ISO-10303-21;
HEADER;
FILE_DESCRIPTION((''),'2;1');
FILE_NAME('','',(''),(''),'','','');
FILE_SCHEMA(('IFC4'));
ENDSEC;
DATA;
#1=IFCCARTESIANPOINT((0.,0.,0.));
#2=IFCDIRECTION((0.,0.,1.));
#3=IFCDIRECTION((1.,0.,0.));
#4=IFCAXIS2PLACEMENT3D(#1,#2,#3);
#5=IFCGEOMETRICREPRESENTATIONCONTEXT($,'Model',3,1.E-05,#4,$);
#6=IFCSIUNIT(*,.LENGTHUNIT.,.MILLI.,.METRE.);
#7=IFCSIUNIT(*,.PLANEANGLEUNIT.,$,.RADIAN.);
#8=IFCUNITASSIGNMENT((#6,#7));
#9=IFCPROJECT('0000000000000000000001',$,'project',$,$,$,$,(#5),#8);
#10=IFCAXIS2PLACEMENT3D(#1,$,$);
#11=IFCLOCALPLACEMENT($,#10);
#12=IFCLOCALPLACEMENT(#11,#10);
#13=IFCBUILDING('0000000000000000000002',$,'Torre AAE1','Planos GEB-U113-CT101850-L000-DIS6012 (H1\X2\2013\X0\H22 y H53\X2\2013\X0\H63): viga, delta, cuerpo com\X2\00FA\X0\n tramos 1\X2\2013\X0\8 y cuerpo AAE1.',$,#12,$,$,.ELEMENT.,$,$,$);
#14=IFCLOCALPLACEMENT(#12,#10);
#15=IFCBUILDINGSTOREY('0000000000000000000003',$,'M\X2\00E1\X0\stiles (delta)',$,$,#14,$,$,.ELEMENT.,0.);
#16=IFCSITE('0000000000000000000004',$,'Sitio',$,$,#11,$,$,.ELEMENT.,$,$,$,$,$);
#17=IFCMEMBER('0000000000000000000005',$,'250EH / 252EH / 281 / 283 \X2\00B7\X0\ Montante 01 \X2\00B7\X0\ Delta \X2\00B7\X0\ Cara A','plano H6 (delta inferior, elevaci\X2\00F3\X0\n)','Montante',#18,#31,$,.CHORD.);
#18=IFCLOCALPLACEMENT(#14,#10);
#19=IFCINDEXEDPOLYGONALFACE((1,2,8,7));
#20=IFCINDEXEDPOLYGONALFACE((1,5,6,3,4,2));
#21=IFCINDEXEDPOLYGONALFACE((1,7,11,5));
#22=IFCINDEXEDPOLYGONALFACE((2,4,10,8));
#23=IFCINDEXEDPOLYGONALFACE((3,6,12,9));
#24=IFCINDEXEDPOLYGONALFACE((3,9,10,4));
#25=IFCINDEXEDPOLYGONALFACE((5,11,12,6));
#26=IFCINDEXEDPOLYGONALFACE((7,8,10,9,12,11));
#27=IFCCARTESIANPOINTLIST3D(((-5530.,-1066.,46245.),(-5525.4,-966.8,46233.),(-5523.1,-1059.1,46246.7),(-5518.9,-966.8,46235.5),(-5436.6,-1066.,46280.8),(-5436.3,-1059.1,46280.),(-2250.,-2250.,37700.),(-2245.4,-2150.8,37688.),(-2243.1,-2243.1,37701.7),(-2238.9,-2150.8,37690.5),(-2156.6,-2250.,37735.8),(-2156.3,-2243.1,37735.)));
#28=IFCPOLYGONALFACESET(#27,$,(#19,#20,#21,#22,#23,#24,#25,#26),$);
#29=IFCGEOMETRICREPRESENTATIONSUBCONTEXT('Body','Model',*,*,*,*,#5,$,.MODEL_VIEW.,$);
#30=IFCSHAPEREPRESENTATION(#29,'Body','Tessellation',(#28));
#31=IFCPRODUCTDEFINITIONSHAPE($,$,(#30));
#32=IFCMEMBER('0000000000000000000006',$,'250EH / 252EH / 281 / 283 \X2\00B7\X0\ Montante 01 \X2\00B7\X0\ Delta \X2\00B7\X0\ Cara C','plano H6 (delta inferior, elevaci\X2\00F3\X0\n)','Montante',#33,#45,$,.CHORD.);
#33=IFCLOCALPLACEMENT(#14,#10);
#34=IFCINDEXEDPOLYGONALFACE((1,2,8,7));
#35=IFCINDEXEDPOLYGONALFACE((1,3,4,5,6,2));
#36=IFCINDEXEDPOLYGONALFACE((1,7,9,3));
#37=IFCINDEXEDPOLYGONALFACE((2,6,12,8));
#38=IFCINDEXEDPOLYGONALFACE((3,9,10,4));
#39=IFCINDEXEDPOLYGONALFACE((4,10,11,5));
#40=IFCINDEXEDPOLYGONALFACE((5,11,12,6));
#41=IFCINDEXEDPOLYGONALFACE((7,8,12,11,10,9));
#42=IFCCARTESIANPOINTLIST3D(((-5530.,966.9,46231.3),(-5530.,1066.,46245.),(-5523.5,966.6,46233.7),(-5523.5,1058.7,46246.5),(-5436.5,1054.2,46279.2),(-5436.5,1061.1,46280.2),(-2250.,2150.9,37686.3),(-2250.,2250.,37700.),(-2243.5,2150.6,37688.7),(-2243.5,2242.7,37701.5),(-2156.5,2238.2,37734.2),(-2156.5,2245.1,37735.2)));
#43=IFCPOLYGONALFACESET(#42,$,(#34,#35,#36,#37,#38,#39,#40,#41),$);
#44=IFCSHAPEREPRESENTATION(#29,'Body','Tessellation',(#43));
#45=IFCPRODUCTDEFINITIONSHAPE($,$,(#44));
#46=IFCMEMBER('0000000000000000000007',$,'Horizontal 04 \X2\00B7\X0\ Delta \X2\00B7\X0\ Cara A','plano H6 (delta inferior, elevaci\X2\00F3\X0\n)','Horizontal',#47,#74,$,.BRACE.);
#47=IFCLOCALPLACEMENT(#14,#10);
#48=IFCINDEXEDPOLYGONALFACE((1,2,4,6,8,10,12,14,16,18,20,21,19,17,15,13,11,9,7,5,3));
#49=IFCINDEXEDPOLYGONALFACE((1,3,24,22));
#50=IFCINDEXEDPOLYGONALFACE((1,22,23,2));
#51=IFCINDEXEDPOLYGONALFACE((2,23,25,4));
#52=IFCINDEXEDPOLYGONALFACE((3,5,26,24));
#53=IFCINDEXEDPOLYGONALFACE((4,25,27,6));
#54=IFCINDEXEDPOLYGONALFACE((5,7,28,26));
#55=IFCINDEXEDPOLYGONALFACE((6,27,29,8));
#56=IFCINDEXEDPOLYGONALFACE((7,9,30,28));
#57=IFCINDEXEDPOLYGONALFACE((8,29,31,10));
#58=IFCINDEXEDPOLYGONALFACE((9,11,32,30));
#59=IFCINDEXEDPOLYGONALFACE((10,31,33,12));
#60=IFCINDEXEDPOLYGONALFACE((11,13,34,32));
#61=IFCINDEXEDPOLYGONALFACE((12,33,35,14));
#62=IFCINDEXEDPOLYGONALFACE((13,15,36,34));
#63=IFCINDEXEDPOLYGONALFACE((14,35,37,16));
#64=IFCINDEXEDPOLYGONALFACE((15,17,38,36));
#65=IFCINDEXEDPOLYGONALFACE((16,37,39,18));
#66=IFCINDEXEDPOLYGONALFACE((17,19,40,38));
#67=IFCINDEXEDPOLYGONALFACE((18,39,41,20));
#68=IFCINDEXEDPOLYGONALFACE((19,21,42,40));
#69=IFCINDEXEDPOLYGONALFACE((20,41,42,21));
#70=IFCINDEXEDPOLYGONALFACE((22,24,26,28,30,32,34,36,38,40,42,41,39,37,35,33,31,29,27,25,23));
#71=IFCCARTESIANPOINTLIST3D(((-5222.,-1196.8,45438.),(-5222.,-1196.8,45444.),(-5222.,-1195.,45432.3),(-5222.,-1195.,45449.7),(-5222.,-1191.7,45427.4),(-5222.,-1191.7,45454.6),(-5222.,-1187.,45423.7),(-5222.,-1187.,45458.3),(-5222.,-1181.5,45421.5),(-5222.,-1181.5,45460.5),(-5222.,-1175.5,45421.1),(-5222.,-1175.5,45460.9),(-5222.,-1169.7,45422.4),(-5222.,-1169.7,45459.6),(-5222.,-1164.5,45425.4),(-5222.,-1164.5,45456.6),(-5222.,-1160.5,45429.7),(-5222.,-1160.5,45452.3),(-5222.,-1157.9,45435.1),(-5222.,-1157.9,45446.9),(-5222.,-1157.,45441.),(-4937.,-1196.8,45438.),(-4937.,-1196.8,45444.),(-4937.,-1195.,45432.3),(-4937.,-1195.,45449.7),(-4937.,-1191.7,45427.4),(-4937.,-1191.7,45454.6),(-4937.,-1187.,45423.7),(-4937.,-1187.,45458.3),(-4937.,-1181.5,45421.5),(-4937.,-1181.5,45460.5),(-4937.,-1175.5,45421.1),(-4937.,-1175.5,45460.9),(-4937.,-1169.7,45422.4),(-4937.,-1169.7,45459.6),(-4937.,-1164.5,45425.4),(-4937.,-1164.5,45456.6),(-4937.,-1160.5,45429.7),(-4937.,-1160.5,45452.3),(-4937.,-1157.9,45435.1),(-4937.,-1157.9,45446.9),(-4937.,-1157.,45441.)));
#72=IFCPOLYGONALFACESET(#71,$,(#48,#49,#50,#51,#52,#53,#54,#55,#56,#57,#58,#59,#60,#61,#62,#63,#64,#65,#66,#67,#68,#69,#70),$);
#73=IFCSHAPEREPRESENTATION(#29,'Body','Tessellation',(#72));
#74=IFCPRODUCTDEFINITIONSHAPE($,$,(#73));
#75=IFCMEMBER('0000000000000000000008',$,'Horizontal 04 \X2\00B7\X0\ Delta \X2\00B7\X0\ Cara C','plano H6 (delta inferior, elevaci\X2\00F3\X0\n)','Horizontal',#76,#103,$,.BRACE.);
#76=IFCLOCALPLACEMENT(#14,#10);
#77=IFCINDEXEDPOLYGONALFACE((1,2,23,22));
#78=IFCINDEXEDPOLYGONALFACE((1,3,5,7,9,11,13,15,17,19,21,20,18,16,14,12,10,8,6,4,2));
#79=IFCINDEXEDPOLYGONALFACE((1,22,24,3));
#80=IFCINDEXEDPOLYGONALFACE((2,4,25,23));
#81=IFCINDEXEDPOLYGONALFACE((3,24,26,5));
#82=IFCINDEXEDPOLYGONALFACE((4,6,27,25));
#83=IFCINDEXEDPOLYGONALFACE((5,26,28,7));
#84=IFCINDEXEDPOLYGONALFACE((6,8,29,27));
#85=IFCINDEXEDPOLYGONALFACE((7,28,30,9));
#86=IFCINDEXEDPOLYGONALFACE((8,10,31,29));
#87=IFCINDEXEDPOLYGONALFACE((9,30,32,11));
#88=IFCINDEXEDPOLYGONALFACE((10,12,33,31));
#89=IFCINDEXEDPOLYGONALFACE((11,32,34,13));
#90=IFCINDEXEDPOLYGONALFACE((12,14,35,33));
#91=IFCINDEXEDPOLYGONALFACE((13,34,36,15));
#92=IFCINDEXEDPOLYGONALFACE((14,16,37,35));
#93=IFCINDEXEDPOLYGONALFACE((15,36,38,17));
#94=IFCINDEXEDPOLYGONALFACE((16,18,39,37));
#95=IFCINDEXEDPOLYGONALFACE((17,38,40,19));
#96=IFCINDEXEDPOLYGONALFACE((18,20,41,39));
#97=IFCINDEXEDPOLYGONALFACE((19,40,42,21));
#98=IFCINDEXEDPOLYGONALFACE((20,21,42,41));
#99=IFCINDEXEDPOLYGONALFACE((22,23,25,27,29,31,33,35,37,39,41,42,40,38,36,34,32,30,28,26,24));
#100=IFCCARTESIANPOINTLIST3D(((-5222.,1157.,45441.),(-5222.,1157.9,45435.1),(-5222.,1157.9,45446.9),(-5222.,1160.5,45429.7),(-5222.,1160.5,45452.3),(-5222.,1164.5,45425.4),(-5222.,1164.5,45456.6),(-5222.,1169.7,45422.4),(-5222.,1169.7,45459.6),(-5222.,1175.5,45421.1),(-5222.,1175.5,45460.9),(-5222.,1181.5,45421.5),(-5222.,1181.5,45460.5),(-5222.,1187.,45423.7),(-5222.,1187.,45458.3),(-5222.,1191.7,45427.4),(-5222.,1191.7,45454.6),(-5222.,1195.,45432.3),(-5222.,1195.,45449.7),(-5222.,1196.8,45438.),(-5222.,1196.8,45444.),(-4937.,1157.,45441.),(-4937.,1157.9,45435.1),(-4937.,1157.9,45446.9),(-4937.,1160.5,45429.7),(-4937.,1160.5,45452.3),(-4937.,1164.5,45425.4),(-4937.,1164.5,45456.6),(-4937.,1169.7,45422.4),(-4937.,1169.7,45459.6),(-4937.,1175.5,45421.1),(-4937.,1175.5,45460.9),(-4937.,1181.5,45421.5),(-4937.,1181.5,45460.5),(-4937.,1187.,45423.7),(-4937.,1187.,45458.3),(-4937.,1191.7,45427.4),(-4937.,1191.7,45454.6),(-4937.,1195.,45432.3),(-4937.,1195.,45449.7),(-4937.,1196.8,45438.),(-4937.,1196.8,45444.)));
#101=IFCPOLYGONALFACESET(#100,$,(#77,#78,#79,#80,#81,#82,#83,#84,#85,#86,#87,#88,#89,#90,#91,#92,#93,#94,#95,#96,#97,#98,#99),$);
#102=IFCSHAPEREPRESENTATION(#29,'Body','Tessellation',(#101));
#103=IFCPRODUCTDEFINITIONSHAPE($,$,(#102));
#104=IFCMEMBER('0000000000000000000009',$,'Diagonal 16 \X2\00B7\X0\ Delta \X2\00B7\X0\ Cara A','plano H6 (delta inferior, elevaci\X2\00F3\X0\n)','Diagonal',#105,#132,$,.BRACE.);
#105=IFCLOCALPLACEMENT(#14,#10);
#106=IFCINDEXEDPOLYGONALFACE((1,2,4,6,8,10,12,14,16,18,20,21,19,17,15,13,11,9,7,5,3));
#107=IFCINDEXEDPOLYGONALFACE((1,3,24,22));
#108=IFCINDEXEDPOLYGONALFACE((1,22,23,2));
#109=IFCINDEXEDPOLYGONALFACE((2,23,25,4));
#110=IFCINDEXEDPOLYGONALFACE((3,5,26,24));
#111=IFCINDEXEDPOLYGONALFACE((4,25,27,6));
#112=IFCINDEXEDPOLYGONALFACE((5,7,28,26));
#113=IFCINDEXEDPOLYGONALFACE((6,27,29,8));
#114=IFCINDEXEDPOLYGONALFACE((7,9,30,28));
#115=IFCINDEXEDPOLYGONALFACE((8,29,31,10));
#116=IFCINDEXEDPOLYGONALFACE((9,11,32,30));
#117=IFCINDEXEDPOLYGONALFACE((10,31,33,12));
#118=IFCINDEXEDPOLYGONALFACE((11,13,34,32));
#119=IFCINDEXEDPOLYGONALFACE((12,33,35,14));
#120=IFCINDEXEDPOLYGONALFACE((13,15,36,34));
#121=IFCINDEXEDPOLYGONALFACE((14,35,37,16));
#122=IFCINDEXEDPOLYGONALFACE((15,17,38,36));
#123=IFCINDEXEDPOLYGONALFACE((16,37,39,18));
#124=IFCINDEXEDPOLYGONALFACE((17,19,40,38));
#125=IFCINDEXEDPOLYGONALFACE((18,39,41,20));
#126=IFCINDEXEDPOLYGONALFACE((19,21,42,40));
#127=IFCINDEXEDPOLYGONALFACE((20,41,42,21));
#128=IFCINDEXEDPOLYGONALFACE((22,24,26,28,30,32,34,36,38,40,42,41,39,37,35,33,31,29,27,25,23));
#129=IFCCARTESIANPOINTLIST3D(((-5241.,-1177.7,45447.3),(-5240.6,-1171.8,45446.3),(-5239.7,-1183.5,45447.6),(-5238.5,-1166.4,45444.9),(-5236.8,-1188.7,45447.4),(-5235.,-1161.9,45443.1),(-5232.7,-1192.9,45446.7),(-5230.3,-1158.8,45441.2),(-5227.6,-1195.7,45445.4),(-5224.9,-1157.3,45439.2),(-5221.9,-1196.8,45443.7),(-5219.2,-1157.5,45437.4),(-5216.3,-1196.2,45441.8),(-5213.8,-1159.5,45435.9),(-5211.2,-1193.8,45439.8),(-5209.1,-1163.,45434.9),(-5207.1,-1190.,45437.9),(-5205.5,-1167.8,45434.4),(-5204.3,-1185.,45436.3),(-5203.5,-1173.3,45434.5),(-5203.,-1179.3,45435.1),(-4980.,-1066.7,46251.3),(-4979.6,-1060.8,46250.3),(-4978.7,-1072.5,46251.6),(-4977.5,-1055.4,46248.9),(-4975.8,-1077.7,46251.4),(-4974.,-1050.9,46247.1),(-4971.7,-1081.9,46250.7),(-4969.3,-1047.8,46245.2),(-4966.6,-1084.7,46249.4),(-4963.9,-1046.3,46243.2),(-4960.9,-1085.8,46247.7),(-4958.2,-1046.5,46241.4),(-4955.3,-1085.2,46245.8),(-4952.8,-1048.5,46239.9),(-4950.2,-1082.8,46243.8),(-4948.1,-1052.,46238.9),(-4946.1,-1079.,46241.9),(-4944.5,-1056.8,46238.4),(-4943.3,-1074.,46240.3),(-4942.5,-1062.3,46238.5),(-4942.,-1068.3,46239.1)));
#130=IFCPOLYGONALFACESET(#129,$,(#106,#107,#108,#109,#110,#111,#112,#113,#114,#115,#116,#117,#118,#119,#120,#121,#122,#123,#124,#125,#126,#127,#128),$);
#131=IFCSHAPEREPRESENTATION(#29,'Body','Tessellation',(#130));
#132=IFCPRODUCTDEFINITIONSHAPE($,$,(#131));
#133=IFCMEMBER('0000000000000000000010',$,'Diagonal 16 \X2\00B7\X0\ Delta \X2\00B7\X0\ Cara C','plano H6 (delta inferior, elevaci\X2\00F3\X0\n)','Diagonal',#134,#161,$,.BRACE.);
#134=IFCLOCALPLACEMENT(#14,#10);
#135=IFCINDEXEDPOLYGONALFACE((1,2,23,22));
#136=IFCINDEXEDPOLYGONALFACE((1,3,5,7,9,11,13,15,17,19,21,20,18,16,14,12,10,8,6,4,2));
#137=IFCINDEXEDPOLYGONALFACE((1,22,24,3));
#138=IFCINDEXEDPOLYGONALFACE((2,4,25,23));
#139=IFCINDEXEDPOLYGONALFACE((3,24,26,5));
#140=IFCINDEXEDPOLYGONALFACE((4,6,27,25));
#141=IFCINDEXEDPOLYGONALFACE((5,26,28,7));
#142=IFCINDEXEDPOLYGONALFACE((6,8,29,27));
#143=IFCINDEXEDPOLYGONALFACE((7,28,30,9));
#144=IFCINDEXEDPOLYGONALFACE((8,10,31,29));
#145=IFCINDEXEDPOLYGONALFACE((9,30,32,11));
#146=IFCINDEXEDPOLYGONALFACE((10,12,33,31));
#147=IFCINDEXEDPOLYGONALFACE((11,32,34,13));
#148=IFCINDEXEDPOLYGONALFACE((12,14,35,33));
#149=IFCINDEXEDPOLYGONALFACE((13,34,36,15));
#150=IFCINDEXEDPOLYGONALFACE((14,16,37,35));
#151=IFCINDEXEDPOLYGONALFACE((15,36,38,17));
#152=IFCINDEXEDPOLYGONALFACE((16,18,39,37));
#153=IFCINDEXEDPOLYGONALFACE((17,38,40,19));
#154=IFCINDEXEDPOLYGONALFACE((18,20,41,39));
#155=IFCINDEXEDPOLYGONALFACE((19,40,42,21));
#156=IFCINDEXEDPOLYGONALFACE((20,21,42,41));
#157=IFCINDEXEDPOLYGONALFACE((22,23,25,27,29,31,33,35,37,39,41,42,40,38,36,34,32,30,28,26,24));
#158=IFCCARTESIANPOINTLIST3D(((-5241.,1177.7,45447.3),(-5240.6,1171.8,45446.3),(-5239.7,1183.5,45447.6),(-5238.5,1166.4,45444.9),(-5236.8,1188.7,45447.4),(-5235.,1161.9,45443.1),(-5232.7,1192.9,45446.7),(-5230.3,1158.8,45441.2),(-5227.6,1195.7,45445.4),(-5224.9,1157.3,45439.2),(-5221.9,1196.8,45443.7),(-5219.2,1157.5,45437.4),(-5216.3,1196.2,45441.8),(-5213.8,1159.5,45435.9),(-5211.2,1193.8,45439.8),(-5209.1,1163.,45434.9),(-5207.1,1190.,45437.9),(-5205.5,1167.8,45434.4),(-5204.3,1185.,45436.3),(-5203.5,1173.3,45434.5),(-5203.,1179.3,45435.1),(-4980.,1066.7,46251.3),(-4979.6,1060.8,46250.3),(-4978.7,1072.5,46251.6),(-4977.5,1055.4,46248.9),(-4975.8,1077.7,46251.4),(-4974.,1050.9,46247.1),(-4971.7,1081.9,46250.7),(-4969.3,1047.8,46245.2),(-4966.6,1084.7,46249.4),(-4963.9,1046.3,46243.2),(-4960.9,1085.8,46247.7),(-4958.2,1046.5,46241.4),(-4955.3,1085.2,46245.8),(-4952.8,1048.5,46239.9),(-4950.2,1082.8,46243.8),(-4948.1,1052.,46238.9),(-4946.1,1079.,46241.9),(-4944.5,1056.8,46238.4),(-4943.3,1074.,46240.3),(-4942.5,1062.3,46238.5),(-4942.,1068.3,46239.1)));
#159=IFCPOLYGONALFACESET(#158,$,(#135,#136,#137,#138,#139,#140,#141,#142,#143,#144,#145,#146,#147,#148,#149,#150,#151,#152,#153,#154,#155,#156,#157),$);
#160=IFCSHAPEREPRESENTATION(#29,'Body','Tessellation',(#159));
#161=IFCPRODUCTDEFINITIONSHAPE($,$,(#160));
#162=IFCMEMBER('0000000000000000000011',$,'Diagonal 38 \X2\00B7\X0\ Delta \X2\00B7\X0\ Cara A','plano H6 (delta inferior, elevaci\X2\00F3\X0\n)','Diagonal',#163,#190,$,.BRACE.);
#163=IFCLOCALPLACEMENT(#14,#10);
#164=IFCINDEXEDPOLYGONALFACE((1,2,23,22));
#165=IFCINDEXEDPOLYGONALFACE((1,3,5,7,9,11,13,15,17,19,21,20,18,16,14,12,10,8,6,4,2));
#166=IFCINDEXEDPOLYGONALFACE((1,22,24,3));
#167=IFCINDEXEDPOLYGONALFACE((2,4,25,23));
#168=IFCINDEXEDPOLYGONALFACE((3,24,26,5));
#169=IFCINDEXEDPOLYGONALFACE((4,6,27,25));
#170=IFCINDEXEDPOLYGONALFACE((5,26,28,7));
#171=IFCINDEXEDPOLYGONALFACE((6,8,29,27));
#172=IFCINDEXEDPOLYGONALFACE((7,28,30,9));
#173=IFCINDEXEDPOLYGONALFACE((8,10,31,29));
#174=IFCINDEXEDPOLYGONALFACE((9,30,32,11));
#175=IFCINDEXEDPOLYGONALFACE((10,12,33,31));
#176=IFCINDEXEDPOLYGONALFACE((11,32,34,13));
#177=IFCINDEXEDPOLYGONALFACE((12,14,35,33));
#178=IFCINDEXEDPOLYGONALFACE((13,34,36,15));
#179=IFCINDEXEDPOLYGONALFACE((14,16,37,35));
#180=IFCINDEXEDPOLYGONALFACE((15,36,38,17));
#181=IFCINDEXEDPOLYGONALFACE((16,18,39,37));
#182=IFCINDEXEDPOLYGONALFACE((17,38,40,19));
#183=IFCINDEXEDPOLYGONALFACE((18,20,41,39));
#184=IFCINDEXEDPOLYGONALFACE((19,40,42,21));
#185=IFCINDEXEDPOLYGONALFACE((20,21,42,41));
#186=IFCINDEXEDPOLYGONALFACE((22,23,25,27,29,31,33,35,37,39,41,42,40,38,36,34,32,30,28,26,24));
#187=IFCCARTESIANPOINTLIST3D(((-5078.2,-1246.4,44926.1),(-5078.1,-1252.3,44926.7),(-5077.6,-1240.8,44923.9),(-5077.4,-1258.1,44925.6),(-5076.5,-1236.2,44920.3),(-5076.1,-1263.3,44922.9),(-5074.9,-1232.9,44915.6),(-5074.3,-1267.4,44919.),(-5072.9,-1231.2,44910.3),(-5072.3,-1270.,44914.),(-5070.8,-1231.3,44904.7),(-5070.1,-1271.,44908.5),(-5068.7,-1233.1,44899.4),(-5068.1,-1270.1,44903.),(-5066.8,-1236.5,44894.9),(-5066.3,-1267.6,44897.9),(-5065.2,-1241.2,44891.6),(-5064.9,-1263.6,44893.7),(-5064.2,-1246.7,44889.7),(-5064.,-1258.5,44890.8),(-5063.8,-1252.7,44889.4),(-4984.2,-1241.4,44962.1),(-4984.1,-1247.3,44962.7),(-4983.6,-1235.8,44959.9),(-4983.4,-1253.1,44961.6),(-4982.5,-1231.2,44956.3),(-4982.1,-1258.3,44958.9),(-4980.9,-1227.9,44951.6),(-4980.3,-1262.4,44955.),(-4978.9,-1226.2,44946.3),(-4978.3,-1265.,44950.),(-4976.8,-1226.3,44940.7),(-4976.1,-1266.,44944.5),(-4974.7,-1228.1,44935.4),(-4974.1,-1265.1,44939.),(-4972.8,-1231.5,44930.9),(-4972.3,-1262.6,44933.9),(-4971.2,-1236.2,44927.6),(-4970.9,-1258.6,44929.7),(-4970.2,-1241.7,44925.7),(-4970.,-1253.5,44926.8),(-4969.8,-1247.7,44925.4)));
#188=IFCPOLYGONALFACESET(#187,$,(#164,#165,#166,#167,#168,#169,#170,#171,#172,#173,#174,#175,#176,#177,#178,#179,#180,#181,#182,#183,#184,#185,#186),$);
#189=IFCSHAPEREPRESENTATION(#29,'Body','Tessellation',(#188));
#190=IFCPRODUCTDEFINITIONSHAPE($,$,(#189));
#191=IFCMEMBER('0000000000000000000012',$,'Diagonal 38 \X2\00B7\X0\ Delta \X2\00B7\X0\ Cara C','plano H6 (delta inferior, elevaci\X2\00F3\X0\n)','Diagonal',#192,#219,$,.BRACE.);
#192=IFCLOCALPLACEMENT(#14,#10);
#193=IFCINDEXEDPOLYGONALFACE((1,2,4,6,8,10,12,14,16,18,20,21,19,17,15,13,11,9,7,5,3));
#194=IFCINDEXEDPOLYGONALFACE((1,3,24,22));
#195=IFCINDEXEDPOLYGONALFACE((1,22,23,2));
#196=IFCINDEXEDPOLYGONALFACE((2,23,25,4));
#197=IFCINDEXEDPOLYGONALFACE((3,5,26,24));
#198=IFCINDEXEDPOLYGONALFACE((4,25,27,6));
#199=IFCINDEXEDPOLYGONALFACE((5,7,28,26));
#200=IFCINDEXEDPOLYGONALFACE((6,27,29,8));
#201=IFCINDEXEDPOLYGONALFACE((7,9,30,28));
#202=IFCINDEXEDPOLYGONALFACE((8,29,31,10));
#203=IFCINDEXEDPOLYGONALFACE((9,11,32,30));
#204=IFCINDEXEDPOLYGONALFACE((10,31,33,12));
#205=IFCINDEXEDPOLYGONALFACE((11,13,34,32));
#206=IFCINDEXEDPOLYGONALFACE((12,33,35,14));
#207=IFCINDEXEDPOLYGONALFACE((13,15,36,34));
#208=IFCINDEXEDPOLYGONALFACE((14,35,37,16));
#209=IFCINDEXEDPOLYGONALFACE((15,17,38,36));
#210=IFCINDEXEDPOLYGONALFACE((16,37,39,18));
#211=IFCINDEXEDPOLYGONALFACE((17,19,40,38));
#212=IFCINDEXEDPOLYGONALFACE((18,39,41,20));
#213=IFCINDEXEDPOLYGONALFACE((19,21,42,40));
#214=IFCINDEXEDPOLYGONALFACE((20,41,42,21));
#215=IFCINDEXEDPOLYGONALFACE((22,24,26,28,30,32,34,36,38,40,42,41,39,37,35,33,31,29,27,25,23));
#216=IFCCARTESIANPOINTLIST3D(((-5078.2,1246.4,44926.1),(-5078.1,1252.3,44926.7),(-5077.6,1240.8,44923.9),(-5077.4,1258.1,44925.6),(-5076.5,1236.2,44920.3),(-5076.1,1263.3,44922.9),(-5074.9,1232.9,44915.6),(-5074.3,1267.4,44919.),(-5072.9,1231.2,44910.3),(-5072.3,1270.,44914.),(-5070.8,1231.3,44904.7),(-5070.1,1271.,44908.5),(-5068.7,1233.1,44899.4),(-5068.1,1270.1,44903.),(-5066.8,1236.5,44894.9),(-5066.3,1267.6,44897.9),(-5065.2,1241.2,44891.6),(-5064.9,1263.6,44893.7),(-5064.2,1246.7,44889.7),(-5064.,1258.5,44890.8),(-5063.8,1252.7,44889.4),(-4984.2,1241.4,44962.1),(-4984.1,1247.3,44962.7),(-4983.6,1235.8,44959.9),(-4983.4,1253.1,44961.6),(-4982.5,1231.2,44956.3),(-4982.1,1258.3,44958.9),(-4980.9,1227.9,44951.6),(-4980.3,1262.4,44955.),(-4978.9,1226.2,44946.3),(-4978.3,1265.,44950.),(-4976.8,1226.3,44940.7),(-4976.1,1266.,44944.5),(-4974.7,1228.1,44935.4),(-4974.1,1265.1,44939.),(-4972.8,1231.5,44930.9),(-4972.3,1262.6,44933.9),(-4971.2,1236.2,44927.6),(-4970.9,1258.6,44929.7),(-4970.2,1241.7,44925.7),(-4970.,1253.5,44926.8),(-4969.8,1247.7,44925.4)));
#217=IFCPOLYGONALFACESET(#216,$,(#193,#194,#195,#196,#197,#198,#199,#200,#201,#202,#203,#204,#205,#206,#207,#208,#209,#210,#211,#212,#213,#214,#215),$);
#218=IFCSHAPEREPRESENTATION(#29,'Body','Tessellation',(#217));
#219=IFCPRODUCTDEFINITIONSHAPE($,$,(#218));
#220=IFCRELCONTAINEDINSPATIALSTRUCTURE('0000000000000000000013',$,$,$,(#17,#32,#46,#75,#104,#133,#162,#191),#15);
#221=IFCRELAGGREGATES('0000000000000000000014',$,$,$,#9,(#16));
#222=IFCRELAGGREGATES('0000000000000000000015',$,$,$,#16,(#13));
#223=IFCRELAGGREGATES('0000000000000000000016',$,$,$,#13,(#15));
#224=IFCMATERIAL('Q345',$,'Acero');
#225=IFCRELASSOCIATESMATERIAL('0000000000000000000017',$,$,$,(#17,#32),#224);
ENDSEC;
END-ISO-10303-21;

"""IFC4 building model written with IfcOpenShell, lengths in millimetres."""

from ifc_helpers import new_model, si_unit, frame, frame_2d, origin, origin_with_axes, place, context, subcontext, project, spatial, circle, l_section, extrude, material, element, save


model = new_model("IFC4")

# Units and contexts
model_context = context("Model", 3, precision=1e-05, world=origin_with_axes())
body_context = subcontext(model_context, "Body", "Model", "MODEL_VIEW")
ifc_project = project(units=[si_unit("LENGTHUNIT", "METRE", prefix="MILLI"), si_unit("PLANEANGLEUNIT", "RADIAN")], contexts=[model_context])

# Site, building, storey
site_placement = place(None, origin())
site = spatial("IfcSite", under=ifc_project, at=site_placement, Name="Sitio", CompositionType="ELEMENT")
building_placement = place(site_placement, origin())
building = spatial("IfcBuilding", under=site, at=building_placement, Name="Torre AAE1", Description="Planos GEB-U113-CT101850-L000-DIS6012 (H1–H22 y H53–H63): viga, delta, cuerpo común tramos 1–8 y cuerpo AAE1.", CompositionType="ELEMENT")
storey_placement = place(building_placement, origin())
storey = spatial("IfcBuildingStorey", under=building, at=storey_placement, Name="Mástiles (delta)", CompositionType="ELEMENT", Elevation=0.0)

# Members
ifc_material = material(Name="Q345", Category="Acero")
for number, where, z_axis, x_axis, name in (
    (1, (-5530.0, -1066.0, 46245.0), (0.355396, -0.128289, -0.92587), (0.045973, 0.991737, -0.119769), "250EH / 252EH / 281 / 283 · Montante 01 · Delta · Cara A"),
    (2, (-5530.0, 1066.0, 46245.0), (0.355396, 0.128289, -0.92587), (0.934716, -0.048778, 0.352032), "250EH / 252EH / 281 / 283 · Montante 01 · Delta · Cara C"),
):
    element("IfcMember", number, at=place(storey_placement, frame(where, z_axis=z_axis, x_axis=x_axis)), inside=storey, material=ifc_material, Name=name, Description="plano H6 (delta inferior, elevación)", ObjectType="Montante", PredefinedType="CHORD", context=body_context, shape_type="SweptSolid", body=[
        extrude(l_section(Depth=100.0, Width=100.0, Thickness=7.0, at=frame_2d((50.0, 50.0))), None, (0.0, 0.0, 1.0), 9229.2),
    ])
for number, where, z_axis, x_axis, name in (
    (3, (-4937.0, -1177.0, 45441.0), (-1.0, 0.0, 0.0), (0.0, 1.0, 0.0), "Horizontal 04 · Delta · Cara A"),
    (4, (-4937.0, 1177.0, 45441.0), (-1.0, 0.0, 0.0), (0.0, -1.0, 0.0), "Horizontal 04 · Delta · Cara C"),
):
    element("IfcMember", number, at=place(storey_placement, frame(where, z_axis=z_axis, x_axis=x_axis)), inside=storey, Name=name, Description="plano H6 (delta inferior, elevación)", ObjectType="Horizontal", PredefinedType="BRACE", context=body_context, shape_type="SweptSolid", body=[
        extrude(circle(Radius=20.0), None, (0.0, 0.0, 1.0), 285.0),
    ])
for number, where, z_axis, x_axis, name in (
    (5, (-5222.0, -1177.0, 45441.0), (0.306137, 0.130196, 0.943042), (0.92747, 0.182577, -0.326288), "Diagonal 16 · Delta · Cara A"),
    (6, (-5222.0, 1177.0, 45441.0), (0.306137, -0.130196, 0.943042), (0.92747, -0.182577, -0.326288), "Diagonal 16 · Delta · Cara C"),
):
    element("IfcMember", number, at=place(storey_placement, frame(where, z_axis=z_axis, x_axis=x_axis)), inside=storey, Name=name, Description="plano H6 (delta inferior, elevación)", ObjectType="Diagonal", PredefinedType="BRACE", context=body_context, shape_type="SweptSolid", body=[
        extrude(circle(Radius=20.0), None, (0.0, 0.0, 1.0), 852.6),
    ])
for number, where, z_axis, x_axis, name in (
    (7, (-4977.0, -1246.0, 44944.0), (-0.932707, -0.049612, -0.357207), (0.288684, 0.490939, -0.821973), "Diagonal 38 · Delta · Cara A"),
    (8, (-4977.0, 1246.0, 44944.0), (-0.932707, 0.049612, -0.357207), (0.288684, -0.490939, -0.821973), "Diagonal 38 · Delta · Cara C"),
):
    element("IfcMember", number, at=place(storey_placement, frame(where, z_axis=z_axis, x_axis=x_axis)), inside=storey, Name=name, Description="plano H6 (delta inferior, elevación)", ObjectType="Diagonal", PredefinedType="BRACE", context=body_context, shape_type="SweptSolid", body=[
        extrude(circle(Radius=20.0), None, (0.0, 0.0, 1.0), 100.8),
    ])

save(model, "model.ifc")
